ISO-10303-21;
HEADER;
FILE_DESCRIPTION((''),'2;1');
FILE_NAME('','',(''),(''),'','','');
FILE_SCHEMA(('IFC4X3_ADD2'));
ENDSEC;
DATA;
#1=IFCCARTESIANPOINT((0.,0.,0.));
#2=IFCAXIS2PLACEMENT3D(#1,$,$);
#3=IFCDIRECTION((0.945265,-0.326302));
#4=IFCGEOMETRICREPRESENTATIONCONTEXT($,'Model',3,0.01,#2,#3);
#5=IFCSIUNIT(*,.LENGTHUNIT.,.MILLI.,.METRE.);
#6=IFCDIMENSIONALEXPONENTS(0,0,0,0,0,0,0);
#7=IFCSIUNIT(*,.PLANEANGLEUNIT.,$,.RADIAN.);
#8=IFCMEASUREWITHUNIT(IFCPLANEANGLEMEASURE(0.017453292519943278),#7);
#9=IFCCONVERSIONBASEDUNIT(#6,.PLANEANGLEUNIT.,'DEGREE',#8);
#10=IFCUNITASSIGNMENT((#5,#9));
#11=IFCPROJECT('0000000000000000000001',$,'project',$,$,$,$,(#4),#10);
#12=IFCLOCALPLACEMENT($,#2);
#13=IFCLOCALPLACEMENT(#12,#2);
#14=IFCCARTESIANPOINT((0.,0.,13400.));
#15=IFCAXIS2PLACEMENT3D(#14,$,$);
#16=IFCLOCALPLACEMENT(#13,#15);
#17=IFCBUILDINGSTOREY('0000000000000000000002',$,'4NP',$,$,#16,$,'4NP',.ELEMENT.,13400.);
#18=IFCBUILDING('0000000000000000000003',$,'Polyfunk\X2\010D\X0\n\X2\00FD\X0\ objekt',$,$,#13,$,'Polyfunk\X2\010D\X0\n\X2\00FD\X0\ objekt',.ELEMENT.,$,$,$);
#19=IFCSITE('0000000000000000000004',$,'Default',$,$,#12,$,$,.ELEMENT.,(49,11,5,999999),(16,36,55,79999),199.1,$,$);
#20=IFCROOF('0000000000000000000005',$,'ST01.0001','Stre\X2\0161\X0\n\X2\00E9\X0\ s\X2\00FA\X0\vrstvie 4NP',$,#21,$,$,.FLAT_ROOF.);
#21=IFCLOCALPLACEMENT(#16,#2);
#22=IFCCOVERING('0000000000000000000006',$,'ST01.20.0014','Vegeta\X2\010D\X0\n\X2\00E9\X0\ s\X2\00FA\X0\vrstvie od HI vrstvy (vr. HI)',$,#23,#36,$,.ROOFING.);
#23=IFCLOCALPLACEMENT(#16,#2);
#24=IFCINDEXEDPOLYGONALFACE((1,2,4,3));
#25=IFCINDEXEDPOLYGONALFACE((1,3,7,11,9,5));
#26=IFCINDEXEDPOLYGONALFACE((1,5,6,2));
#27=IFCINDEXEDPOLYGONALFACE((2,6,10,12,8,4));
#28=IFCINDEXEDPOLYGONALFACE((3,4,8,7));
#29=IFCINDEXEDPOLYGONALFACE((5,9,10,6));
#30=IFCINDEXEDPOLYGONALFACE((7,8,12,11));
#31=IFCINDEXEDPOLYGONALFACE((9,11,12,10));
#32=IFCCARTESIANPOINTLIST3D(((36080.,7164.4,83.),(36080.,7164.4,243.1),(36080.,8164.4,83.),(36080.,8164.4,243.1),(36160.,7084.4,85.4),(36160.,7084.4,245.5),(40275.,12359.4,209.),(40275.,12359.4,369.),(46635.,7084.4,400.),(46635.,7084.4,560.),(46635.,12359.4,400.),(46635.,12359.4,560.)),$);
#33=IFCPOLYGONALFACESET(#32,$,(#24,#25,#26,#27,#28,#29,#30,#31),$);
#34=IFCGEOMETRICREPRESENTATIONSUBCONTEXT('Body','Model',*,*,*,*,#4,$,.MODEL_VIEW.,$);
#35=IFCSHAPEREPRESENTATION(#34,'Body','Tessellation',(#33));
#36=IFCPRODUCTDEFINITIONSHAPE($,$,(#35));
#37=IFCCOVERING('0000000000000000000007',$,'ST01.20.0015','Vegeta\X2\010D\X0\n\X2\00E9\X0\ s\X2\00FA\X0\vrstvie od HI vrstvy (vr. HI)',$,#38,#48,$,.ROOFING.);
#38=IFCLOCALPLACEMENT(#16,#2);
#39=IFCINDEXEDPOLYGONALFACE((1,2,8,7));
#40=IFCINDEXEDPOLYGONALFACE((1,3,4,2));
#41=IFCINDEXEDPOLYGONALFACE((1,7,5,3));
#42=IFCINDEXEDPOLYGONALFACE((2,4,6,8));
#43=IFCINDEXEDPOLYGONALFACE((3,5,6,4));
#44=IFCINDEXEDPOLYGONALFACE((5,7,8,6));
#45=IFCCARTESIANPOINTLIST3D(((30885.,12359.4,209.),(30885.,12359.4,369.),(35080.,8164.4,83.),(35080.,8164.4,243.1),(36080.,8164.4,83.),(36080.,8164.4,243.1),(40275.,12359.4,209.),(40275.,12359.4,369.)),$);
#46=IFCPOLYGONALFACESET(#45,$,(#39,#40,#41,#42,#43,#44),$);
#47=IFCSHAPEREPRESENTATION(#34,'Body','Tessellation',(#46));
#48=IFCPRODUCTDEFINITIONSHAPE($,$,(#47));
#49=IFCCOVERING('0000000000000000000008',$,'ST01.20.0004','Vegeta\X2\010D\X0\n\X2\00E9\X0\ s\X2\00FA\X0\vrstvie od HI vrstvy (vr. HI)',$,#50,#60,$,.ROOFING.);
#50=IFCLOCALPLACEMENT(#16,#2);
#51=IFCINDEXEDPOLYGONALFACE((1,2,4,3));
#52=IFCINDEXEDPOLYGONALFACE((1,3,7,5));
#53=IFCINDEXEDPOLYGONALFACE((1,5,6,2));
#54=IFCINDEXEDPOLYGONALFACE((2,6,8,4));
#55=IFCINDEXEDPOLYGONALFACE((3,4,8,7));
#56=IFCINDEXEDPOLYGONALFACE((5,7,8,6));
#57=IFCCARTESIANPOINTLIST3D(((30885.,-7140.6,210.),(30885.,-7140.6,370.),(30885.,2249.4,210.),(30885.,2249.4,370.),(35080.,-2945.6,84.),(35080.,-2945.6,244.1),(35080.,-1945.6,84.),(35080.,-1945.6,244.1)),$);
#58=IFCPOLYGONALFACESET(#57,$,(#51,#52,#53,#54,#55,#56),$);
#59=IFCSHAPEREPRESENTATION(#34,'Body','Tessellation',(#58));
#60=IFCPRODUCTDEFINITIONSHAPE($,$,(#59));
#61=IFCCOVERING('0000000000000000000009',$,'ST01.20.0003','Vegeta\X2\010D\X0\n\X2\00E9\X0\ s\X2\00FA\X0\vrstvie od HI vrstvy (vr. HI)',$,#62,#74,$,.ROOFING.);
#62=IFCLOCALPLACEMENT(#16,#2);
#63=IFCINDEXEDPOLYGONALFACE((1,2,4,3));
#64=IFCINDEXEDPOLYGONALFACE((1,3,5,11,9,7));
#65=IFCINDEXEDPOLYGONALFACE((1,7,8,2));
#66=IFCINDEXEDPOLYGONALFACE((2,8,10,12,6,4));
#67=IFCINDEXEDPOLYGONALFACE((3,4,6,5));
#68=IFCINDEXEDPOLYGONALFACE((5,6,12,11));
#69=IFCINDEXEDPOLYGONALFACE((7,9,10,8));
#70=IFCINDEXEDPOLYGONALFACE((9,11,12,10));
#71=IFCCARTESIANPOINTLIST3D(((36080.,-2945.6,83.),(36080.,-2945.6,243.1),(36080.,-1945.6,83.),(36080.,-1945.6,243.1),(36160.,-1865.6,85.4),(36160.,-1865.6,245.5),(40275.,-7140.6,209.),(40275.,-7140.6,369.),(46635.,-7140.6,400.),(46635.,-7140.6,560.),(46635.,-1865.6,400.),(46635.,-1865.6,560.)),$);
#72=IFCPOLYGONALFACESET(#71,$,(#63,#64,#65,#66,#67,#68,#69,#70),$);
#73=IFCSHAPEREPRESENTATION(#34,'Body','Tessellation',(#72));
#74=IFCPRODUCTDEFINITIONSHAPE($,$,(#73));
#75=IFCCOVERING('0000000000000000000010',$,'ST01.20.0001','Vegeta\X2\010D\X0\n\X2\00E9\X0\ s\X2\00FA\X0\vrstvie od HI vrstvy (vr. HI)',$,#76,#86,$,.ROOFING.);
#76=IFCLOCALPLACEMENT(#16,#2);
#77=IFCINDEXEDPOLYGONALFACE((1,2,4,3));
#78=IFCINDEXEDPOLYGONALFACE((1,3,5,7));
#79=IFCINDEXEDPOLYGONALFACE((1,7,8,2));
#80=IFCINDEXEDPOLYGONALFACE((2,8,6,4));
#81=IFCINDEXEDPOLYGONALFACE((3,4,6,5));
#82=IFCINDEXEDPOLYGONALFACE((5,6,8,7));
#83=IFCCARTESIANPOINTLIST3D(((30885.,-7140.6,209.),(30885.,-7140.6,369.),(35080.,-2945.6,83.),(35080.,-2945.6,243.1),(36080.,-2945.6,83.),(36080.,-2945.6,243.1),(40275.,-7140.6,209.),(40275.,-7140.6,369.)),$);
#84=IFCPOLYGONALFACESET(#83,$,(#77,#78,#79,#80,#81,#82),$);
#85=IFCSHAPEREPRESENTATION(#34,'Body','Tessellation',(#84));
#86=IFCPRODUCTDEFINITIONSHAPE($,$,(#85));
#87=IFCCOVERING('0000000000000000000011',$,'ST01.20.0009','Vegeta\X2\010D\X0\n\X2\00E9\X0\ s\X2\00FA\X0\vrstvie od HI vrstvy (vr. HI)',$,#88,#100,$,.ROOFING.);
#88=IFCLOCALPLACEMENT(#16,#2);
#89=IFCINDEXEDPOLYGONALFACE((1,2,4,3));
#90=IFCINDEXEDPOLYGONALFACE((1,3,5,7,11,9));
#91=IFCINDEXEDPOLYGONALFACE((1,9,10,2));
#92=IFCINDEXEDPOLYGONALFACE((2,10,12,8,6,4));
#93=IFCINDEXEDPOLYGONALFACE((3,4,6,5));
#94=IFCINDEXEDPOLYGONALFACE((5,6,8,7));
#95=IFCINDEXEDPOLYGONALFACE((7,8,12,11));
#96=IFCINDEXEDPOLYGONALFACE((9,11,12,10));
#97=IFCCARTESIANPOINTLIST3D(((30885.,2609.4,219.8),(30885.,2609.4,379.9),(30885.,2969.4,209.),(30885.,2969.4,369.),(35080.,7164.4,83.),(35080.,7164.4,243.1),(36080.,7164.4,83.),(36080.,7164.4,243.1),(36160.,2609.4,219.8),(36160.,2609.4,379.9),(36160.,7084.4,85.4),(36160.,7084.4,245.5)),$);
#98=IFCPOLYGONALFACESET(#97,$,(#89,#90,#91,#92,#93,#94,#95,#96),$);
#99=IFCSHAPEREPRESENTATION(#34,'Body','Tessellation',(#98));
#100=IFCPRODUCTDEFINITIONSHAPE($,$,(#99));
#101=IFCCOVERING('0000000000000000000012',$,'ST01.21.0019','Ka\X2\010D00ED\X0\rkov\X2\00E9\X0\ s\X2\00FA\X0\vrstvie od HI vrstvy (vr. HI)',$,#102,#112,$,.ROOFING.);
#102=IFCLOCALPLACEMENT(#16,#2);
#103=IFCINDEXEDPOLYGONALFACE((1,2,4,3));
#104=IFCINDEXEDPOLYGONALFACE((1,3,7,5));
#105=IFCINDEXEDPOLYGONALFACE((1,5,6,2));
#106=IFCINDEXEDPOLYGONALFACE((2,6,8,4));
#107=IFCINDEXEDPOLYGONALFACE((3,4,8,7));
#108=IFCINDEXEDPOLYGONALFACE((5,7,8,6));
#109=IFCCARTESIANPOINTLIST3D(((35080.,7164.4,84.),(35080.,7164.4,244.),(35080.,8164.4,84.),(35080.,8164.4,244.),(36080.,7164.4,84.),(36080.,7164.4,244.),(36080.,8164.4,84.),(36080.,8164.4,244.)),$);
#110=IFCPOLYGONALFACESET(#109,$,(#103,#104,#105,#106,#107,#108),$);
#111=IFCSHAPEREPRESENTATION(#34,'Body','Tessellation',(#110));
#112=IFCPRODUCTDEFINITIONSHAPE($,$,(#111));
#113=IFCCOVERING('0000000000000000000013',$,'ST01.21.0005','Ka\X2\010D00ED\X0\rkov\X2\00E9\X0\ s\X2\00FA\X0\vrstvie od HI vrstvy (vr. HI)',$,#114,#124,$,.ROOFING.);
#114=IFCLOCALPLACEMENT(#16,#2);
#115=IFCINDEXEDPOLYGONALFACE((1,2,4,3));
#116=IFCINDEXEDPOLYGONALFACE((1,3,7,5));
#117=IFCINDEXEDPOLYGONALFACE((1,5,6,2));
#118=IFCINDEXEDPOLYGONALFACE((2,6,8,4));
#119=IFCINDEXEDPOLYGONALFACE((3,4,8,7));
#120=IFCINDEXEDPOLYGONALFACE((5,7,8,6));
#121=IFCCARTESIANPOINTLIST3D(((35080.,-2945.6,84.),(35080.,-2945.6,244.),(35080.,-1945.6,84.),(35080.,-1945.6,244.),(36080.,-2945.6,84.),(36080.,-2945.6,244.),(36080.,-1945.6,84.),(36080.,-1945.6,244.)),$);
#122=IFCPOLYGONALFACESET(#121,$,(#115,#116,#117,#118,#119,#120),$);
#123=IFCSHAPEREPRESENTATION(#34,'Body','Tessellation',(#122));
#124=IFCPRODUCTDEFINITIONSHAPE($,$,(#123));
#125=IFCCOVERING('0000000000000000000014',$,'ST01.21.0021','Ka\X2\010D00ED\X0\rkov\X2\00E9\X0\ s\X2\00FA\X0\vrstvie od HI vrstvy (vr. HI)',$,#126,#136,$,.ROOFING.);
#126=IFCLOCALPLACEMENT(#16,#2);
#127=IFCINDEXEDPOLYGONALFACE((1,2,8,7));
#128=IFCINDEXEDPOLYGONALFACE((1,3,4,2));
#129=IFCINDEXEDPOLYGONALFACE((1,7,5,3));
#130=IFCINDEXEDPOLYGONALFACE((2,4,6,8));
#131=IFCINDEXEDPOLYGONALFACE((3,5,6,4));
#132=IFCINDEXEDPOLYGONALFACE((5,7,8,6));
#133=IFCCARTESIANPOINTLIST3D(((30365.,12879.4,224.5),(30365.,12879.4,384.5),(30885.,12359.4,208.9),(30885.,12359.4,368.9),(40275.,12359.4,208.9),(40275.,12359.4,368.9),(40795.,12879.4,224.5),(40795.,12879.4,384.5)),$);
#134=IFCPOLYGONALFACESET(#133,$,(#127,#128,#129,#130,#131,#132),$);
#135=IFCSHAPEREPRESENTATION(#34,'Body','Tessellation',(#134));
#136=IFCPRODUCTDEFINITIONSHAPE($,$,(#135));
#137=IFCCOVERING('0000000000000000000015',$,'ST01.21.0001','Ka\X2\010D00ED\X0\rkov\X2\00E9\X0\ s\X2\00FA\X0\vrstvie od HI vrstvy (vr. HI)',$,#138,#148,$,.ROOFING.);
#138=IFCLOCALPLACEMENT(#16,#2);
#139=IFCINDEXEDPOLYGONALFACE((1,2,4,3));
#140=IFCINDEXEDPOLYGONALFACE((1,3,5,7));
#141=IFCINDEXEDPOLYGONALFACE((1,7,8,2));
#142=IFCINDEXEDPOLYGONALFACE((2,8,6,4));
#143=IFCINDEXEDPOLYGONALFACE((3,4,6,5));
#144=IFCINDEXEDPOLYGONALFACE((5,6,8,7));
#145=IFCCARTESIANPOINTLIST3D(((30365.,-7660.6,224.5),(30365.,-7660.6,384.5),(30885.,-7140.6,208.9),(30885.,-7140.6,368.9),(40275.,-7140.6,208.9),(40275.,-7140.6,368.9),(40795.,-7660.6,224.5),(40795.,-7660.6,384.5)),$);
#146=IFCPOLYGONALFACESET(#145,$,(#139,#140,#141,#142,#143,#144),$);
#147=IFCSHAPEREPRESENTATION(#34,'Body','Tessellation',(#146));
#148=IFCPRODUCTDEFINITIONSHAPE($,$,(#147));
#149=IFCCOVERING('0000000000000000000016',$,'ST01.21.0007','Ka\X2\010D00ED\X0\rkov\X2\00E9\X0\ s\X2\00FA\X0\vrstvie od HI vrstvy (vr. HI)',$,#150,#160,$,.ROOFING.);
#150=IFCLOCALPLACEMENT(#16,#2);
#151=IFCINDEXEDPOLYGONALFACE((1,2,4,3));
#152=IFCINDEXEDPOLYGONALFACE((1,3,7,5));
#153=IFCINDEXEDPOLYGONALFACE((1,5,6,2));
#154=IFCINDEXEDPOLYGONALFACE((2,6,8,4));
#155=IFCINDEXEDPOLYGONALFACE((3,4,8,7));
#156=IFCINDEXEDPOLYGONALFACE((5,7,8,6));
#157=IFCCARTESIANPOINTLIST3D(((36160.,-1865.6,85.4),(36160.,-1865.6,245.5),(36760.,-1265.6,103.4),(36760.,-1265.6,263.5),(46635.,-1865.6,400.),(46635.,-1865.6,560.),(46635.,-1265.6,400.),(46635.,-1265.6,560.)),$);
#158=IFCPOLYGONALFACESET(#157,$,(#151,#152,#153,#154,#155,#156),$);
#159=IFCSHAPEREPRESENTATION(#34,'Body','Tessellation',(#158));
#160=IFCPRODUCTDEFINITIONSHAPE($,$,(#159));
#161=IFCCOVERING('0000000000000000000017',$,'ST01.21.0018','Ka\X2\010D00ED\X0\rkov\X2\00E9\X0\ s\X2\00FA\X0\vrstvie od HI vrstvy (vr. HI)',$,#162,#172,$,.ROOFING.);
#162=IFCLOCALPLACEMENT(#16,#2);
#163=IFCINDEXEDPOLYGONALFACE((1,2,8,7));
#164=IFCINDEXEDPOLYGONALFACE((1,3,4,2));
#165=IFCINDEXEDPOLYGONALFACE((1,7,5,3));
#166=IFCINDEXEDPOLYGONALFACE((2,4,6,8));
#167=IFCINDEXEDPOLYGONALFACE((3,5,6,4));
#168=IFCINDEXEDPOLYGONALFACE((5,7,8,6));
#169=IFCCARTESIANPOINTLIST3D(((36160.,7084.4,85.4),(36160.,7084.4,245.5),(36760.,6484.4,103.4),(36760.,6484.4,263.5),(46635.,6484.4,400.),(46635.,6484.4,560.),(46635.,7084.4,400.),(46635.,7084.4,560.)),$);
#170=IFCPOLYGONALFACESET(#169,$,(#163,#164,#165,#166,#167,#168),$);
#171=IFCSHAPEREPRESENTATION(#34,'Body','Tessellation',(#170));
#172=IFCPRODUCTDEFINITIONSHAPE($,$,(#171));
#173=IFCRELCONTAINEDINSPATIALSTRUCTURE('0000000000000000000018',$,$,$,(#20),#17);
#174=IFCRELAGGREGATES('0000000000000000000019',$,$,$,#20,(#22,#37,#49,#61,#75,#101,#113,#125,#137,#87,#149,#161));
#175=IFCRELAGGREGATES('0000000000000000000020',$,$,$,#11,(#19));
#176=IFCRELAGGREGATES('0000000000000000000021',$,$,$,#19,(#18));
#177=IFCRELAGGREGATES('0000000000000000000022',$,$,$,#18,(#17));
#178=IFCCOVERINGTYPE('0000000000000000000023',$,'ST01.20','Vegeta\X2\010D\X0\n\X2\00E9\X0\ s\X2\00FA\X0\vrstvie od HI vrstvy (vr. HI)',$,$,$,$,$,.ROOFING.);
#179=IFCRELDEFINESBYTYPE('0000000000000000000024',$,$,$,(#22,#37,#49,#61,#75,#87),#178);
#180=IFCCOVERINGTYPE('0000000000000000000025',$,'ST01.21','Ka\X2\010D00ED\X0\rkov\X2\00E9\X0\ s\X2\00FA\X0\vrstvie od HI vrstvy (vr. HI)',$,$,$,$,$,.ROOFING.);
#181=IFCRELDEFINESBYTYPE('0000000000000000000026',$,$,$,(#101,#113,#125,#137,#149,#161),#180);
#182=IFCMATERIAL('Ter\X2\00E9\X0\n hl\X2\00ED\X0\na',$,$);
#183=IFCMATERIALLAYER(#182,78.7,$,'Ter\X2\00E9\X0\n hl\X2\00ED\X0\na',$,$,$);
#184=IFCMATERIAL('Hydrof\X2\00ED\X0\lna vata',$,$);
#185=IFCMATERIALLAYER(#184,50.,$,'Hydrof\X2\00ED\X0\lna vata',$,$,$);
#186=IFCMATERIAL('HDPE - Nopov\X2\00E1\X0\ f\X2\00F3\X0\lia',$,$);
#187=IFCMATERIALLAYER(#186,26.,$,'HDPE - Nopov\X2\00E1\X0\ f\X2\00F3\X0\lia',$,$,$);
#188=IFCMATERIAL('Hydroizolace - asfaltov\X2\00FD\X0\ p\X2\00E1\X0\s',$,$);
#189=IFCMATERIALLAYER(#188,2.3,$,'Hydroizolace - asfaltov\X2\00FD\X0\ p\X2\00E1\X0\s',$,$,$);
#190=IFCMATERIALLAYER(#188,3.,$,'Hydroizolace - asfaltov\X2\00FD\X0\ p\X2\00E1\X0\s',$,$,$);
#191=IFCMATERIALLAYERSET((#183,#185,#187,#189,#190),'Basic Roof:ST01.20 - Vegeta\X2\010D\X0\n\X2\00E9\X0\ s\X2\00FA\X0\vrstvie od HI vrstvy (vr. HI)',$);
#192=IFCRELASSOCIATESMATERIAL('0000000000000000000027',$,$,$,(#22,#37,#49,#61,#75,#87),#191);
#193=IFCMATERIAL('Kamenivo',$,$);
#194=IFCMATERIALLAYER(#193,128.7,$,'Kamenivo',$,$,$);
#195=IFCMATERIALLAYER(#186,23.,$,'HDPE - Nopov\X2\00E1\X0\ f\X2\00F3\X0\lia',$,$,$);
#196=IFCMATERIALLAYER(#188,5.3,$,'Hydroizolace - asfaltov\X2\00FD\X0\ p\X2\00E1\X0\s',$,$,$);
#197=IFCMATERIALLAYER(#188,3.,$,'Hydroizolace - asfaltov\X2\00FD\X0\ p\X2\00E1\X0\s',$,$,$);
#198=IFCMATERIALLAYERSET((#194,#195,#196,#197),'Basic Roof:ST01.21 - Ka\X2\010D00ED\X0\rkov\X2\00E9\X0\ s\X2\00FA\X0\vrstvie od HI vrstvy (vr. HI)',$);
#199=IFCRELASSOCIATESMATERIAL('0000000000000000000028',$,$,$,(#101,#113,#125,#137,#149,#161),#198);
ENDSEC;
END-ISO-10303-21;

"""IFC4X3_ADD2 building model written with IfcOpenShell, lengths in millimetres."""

from ifc_helpers import new_model, entity, si_unit, converted_unit, direction, frame, frame_2d, origin, origin_2d_with_axis, place, context, subcontext, project, spatial, polyline, rectangle, outline, extrude, material, layer, layer_set, type_object, element, aggregate, save


model = new_model("IFC4X3_ADD2")

# Units and contexts
model_context = context("Model", 3, precision=0.01, world=origin(), true_north=direction((0.945265, -0.326302)))
body_context = subcontext(model_context, "Body", "Model", "MODEL_VIEW")
ifc_project = project(units=[si_unit("LENGTHUNIT", "METRE", prefix="MILLI"), converted_unit("PLANEANGLEUNIT", "DEGREE", entity("IfcPlaneAngleMeasure", 0.017453292519943278), si_unit("PLANEANGLEUNIT", "RADIAN"), dimensions=[0, 0, 0, 0, 0, 0, 0])], contexts=[model_context])

# Site, building, storey
site_placement = place(None, origin())
site = spatial("IfcSite", under=ifc_project, at=site_placement, Name="Default", CompositionType="ELEMENT", RefLatitude=(49, 11, 5, 999999), RefLongitude=(16, 36, 55, 79999), RefElevation=199.1)
building_placement = place(site_placement, origin())
building = spatial("IfcBuilding", under=site, at=building_placement, Name="Polyfunkčný objekt", LongName="Polyfunkčný objekt", CompositionType="ELEMENT")
storey_placement = place(building_placement, frame((0.0, 0.0, 13400.0)))
storey = spatial("IfcBuildingStorey", under=building, at=storey_placement, Name="4NP", LongName="4NP", CompositionType="ELEMENT", Elevation=13400.0)

# Roof, coverings
roof = element("IfcRoof", 1, inside=storey, Name="ST01.0001", Description="Strešné súvrstvie 4NP", PredefinedType="FLAT_ROOF")
ifc_material_1 = material(Name="Hydroizolace - asfaltový pás")
ifc_material_2 = material(Name="Terén hlína")
ifc_layer_1 = layer(ifc_material_2, 78.7, Name="Terén hlína")
ifc_material_3 = material(Name="Hydrofílna vata")
ifc_layer_2 = layer(ifc_material_3, 50.0, Name="Hydrofílna vata")
ifc_material_4 = material(Name="HDPE - Nopová fólia")
ifc_layer_3 = layer(ifc_material_4, 26.0, Name="HDPE - Nopová fólia")
ifc_layer_4 = layer(ifc_material_1, 2.3, Name="Hydroizolace - asfaltový pás")
ifc_layer_5 = layer(ifc_material_1, 3.0, Name="Hydroizolace - asfaltový pás")
ifc_layer_set_1 = layer_set([ifc_layer_1, ifc_layer_2, ifc_layer_3, ifc_layer_4, ifc_layer_5], Name="Basic Roof:ST01.20 - Vegetačné súvrstvie od HI vrstvy (vr. HI)")
covering_type_1 = type_object("IfcCoveringType", Name="ST01.20", Description="Vegetačné súvrstvie od HI vrstvy (vr. HI)", PredefinedType="ROOFING")
placement_1 = place(storey_placement, frame((36080.0, 7084.4, 83.0)))
covering_1_placement = place(placement_1, origin())
covering_1 = element("IfcCovering", 2, at=covering_1_placement, type_object=covering_type_1, material=ifc_layer_set_1, Name="ST01.20.0014", Description="Vegetačné súvrstvie od HI vrstvy (vr. HI)", PredefinedType="ROOFING", context=body_context, shape_type="SweptSolid", body=[
    extrude(outline(polyline([(-5279.9, -2557.5), (-5199.8, -2637.5), (5279.9, -2637.5), (5279.9, 2637.5), (-1083.0, 2637.5), (-5279.9, -1557.5), (-5279.9, -2557.5)])), frame((5277.5, 2637.5, 158.5), z_axis=(-0.030015, 0.0, 0.999549), x_axis=(0.999549, 0.0, 0.030015)), (0.030015, 0.0, 0.999549), 160.1),
])
placement_2 = place(storey_placement, frame((30885.0, 8164.4, 83.0)))
covering_2_placement = place(placement_2, origin())
covering_2 = element("IfcCovering", 3, at=covering_2_placement, type_object=covering_type_1, material=ifc_layer_set_1, Name="ST01.20.0015", Description="Vegetačné súvrstvie od HI vrstvy (vr. HI)", PredefinedType="ROOFING", context=body_context, shape_type="SweptSolid", body=[
    extrude(outline(polyline([(500.0, -2098.4), (4695.0, 2098.4), (-4695.0, 2098.4), (-500.0, -2098.4), (500.0, -2098.4)])), frame((4695.0, 2097.5, 63.0), z_axis=(0.0, -0.030015, 0.999549), x_axis=(1.0, 0.0, 0.0)), (0.0, 0.030015, 0.999549), 160.1),
])
placement_3 = place(storey_placement, frame((30885.0, -7140.6, 84.0)))
covering_3_placement = place(placement_3, origin())
covering_3 = element("IfcCovering", 4, at=covering_3_placement, type_object=covering_type_1, material=ifc_layer_set_1, Name="ST01.20.0004", Description="Vegetačné súvrstvie od HI vrstvy (vr. HI)", PredefinedType="ROOFING", context=body_context, shape_type="SweptSolid", body=[
    extrude(outline(polyline([(2098.4, 500.0), (-2098.4, 4695.0), (-2098.4, -4695.0), (2098.4, -500.0), (2098.4, 500.0)])), frame((2097.5, 4695.0, 63.0), z_axis=(0.030015, 0.0, 0.999549), x_axis=(0.999549, 0.0, -0.030015)), (-0.030015, 0.0, 0.999549), 160.1),
])
placement_4 = place(storey_placement, frame((36080.0, -7140.6, 83.0)))
covering_4_placement = place(placement_4, origin())
covering_4 = element("IfcCovering", 5, at=covering_4_placement, type_object=covering_type_1, material=ifc_layer_set_1, Name="ST01.20.0003", Description="Vegetačné súvrstvie od HI vrstvy (vr. HI)", PredefinedType="ROOFING", context=body_context, shape_type="SweptSolid", body=[
    extrude(outline(polyline([(-5279.9, 1557.5), (-1083.0, -2637.5), (5279.9, -2637.5), (5279.9, 2637.5), (-5199.8, 2637.5), (-5279.9, 2557.5), (-5279.9, 1557.5)])), frame((5277.5, 2637.5, 158.5), z_axis=(-0.030015, 0.0, 0.999549), x_axis=(0.999549, 0.0, 0.030015)), (0.030015, 0.0, 0.999549), 160.1),
])
placement_5 = place(storey_placement, frame((30885.0, -7140.6, 83.0)))
covering_5_placement = place(placement_5, origin())
covering_5 = element("IfcCovering", 6, at=covering_5_placement, type_object=covering_type_1, material=ifc_layer_set_1, Name="ST01.20.0001", Description="Vegetačné súvrstvie od HI vrstvy (vr. HI)", PredefinedType="ROOFING", context=body_context, shape_type="SweptSolid", body=[
    extrude(outline(polyline([(-500.0, 2098.4), (-4695.0, -2098.4), (4695.0, -2098.4), (500.0, 2098.4), (-500.0, 2098.4)])), frame((4695.0, 2097.5, 63.0), z_axis=(0.0, 0.030015, 0.999549), x_axis=(1.0, 0.0, 0.0)), (0.0, -0.030015, 0.999549), 160.1),
])
placement_6 = place(storey_placement, frame((30885.0, 2609.4, 83.0)))
covering_6_placement = place(placement_6, origin())
covering_6 = element("IfcCovering", 7, at=covering_6_placement, type_object=covering_type_1, material=ifc_layer_set_1, Name="ST01.20.0009", Description="Vegetačné súvrstvie od HI vrstvy (vr. HI)", PredefinedType="ROOFING", context=body_context, shape_type="SweptSolid", body=[
    extrude(outline(polyline([(1557.5, 2278.5), (-2637.5, -1918.4), (-2637.5, -2278.5), (2637.5, -2278.5), (2637.5, 2198.5), (2557.5, 2278.5), (1557.5, 2278.5)])), frame((2637.5, 2277.5, 68.4), z_axis=(0.0, 0.030015, 0.999549), x_axis=(1.0, 0.0, 0.0)), (0.0, -0.030015, 0.999549), 160.1),
])
ifc_material_5 = material(Name="Kamenivo")
ifc_layer_6 = layer(ifc_material_5, 128.7, Name="Kamenivo")
ifc_layer_7 = layer(ifc_material_4, 23.0, Name="HDPE - Nopová fólia")
ifc_layer_8 = layer(ifc_material_1, 5.3, Name="Hydroizolace - asfaltový pás")
ifc_layer_9 = layer(ifc_material_1, 3.0, Name="Hydroizolace - asfaltový pás")
ifc_layer_set_2 = layer_set([ifc_layer_6, ifc_layer_7, ifc_layer_8, ifc_layer_9], Name="Basic Roof:ST01.21 - Kačírkové súvrstvie od HI vrstvy (vr. HI)")
covering_type_2 = type_object("IfcCoveringType", Name="ST01.21", Description="Kačírkové súvrstvie od HI vrstvy (vr. HI)", PredefinedType="ROOFING")
placement_7 = place(storey_placement, frame((35080.0, 7164.4, 84.0)))
covering_7_placement = place(placement_7, origin())
covering_7 = element("IfcCovering", 8, at=covering_7_placement, type_object=covering_type_2, material=ifc_layer_set_2, Name="ST01.21.0019", Description="Kačírkové súvrstvie od HI vrstvy (vr. HI)", PredefinedType="ROOFING", context=body_context, shape_type="SweptSolid", body=[
    extrude(rectangle(XDim=1000.0, YDim=1000.0, at=frame_2d((0.0, 0.0), x_axis=(1.0, 0.0))), frame((500.0, 500.0, 0.0)), (0.0, 0.0, 1.0), 160.0),
])
covering_8_placement = place(storey_placement, frame((35080.0, -2945.6, 84.0)))
covering_8 = element("IfcCovering", 9, at=covering_8_placement, type_object=covering_type_2, material=ifc_layer_set_2, Name="ST01.21.0005", Description="Kačírkové súvrstvie od HI vrstvy (vr. HI)", PredefinedType="ROOFING", context=body_context, shape_type="SweptSolid", body=[
    extrude(rectangle(XDim=1000.0, YDim=1000.0, at=origin_2d_with_axis()), frame((500.0, 500.0, 0.0), z_axis=(0.0, 0.0, 1.0), x_axis=(0.0, -1.0, 0.0)), (0.0, 0.0, 1.0), 160.0),
])
placement_8 = place(storey_placement, frame((30365.0, 12359.4, 208.9)))
covering_9_placement = place(placement_8, origin())
covering_9 = element("IfcCovering", 10, at=covering_9_placement, type_object=covering_type_2, material=ifc_layer_set_2, Name="ST01.21.0021", Description="Kačírkové súvrstvie od HI vrstvy (vr. HI)", PredefinedType="ROOFING", context=body_context, shape_type="SweptSolid", body=[
    extrude(outline(polyline([(4695.0, -260.1), (5215.0, 260.1), (-5215.0, 260.1), (-4695.0, -260.1), (4695.0, -260.1)])), frame((5215.0, 260.0, 7.8), z_axis=(0.0, -0.030015, 0.999549), x_axis=(1.0, 0.0, 0.0)), (0.0, 0.030015, 0.999549), 160.1),
])
placement_9 = place(storey_placement, frame((30365.0, -7660.6, 208.9)))
covering_10_placement = place(placement_9, origin())
covering_10 = element("IfcCovering", 11, at=covering_10_placement, type_object=covering_type_2, material=ifc_layer_set_2, Name="ST01.21.0001", Description="Kačírkové súvrstvie od HI vrstvy (vr. HI)", PredefinedType="ROOFING", context=body_context, shape_type="SweptSolid", body=[
    extrude(outline(polyline([(-4695.0, 260.1), (-5215.0, -260.1), (5215.0, -260.1), (4695.0, 260.1), (-4695.0, 260.1)])), frame((5215.0, 260.0, 7.8), z_axis=(0.0, 0.030015, 0.999549), x_axis=(1.0, 0.0, 0.0)), (0.0, -0.030015, 0.999549), 160.1),
])
placement_10 = place(storey_placement, frame((36160.0, -1865.6, 85.4)))
covering_11_placement = place(placement_10, origin())
covering_11 = element("IfcCovering", 12, at=covering_11_placement, type_object=covering_type_2, material=ifc_layer_set_2, Name="ST01.21.0007", Description="Kačírkové súvrstvie od HI vrstvy (vr. HI)", PredefinedType="ROOFING", context=body_context, shape_type="SweptSolid", body=[
    extrude(outline(polyline([(-5239.9, -300.0), (5239.9, -300.0), (5239.9, 300.0), (-4639.6, 300.0), (-5239.9, -300.0)])), frame((5237.5, 300.0, 157.3), z_axis=(-0.030015, 0.0, 0.999549), x_axis=(0.999549, 0.0, 0.030015)), (0.030015, 0.0, 0.999549), 160.1),
])
placement_11 = place(storey_placement, frame((36160.0, 6484.4, 85.4)))
covering_12_placement = place(placement_11, origin())
covering_12 = element("IfcCovering", 13, at=covering_12_placement, type_object=covering_type_2, material=ifc_layer_set_2, Name="ST01.21.0018", Description="Kačírkové súvrstvie od HI vrstvy (vr. HI)", PredefinedType="ROOFING", context=body_context, shape_type="SweptSolid", body=[
    extrude(outline(polyline([(-4639.6, -300.0), (5239.9, -300.0), (5239.9, 300.0), (-5239.9, 300.0), (-4639.6, -300.0)])), frame((5237.5, 300.0, 157.3), z_axis=(-0.030015, 0.0, 0.999549), x_axis=(0.999549, 0.0, 0.030015)), (0.030015, 0.0, 0.999549), 160.1),
])
aggregate(roof, [covering_1, covering_2, covering_3, covering_4, covering_5, covering_7, covering_8, covering_9, covering_10, covering_6, covering_11, covering_12])

save(model, "model.ifc")
